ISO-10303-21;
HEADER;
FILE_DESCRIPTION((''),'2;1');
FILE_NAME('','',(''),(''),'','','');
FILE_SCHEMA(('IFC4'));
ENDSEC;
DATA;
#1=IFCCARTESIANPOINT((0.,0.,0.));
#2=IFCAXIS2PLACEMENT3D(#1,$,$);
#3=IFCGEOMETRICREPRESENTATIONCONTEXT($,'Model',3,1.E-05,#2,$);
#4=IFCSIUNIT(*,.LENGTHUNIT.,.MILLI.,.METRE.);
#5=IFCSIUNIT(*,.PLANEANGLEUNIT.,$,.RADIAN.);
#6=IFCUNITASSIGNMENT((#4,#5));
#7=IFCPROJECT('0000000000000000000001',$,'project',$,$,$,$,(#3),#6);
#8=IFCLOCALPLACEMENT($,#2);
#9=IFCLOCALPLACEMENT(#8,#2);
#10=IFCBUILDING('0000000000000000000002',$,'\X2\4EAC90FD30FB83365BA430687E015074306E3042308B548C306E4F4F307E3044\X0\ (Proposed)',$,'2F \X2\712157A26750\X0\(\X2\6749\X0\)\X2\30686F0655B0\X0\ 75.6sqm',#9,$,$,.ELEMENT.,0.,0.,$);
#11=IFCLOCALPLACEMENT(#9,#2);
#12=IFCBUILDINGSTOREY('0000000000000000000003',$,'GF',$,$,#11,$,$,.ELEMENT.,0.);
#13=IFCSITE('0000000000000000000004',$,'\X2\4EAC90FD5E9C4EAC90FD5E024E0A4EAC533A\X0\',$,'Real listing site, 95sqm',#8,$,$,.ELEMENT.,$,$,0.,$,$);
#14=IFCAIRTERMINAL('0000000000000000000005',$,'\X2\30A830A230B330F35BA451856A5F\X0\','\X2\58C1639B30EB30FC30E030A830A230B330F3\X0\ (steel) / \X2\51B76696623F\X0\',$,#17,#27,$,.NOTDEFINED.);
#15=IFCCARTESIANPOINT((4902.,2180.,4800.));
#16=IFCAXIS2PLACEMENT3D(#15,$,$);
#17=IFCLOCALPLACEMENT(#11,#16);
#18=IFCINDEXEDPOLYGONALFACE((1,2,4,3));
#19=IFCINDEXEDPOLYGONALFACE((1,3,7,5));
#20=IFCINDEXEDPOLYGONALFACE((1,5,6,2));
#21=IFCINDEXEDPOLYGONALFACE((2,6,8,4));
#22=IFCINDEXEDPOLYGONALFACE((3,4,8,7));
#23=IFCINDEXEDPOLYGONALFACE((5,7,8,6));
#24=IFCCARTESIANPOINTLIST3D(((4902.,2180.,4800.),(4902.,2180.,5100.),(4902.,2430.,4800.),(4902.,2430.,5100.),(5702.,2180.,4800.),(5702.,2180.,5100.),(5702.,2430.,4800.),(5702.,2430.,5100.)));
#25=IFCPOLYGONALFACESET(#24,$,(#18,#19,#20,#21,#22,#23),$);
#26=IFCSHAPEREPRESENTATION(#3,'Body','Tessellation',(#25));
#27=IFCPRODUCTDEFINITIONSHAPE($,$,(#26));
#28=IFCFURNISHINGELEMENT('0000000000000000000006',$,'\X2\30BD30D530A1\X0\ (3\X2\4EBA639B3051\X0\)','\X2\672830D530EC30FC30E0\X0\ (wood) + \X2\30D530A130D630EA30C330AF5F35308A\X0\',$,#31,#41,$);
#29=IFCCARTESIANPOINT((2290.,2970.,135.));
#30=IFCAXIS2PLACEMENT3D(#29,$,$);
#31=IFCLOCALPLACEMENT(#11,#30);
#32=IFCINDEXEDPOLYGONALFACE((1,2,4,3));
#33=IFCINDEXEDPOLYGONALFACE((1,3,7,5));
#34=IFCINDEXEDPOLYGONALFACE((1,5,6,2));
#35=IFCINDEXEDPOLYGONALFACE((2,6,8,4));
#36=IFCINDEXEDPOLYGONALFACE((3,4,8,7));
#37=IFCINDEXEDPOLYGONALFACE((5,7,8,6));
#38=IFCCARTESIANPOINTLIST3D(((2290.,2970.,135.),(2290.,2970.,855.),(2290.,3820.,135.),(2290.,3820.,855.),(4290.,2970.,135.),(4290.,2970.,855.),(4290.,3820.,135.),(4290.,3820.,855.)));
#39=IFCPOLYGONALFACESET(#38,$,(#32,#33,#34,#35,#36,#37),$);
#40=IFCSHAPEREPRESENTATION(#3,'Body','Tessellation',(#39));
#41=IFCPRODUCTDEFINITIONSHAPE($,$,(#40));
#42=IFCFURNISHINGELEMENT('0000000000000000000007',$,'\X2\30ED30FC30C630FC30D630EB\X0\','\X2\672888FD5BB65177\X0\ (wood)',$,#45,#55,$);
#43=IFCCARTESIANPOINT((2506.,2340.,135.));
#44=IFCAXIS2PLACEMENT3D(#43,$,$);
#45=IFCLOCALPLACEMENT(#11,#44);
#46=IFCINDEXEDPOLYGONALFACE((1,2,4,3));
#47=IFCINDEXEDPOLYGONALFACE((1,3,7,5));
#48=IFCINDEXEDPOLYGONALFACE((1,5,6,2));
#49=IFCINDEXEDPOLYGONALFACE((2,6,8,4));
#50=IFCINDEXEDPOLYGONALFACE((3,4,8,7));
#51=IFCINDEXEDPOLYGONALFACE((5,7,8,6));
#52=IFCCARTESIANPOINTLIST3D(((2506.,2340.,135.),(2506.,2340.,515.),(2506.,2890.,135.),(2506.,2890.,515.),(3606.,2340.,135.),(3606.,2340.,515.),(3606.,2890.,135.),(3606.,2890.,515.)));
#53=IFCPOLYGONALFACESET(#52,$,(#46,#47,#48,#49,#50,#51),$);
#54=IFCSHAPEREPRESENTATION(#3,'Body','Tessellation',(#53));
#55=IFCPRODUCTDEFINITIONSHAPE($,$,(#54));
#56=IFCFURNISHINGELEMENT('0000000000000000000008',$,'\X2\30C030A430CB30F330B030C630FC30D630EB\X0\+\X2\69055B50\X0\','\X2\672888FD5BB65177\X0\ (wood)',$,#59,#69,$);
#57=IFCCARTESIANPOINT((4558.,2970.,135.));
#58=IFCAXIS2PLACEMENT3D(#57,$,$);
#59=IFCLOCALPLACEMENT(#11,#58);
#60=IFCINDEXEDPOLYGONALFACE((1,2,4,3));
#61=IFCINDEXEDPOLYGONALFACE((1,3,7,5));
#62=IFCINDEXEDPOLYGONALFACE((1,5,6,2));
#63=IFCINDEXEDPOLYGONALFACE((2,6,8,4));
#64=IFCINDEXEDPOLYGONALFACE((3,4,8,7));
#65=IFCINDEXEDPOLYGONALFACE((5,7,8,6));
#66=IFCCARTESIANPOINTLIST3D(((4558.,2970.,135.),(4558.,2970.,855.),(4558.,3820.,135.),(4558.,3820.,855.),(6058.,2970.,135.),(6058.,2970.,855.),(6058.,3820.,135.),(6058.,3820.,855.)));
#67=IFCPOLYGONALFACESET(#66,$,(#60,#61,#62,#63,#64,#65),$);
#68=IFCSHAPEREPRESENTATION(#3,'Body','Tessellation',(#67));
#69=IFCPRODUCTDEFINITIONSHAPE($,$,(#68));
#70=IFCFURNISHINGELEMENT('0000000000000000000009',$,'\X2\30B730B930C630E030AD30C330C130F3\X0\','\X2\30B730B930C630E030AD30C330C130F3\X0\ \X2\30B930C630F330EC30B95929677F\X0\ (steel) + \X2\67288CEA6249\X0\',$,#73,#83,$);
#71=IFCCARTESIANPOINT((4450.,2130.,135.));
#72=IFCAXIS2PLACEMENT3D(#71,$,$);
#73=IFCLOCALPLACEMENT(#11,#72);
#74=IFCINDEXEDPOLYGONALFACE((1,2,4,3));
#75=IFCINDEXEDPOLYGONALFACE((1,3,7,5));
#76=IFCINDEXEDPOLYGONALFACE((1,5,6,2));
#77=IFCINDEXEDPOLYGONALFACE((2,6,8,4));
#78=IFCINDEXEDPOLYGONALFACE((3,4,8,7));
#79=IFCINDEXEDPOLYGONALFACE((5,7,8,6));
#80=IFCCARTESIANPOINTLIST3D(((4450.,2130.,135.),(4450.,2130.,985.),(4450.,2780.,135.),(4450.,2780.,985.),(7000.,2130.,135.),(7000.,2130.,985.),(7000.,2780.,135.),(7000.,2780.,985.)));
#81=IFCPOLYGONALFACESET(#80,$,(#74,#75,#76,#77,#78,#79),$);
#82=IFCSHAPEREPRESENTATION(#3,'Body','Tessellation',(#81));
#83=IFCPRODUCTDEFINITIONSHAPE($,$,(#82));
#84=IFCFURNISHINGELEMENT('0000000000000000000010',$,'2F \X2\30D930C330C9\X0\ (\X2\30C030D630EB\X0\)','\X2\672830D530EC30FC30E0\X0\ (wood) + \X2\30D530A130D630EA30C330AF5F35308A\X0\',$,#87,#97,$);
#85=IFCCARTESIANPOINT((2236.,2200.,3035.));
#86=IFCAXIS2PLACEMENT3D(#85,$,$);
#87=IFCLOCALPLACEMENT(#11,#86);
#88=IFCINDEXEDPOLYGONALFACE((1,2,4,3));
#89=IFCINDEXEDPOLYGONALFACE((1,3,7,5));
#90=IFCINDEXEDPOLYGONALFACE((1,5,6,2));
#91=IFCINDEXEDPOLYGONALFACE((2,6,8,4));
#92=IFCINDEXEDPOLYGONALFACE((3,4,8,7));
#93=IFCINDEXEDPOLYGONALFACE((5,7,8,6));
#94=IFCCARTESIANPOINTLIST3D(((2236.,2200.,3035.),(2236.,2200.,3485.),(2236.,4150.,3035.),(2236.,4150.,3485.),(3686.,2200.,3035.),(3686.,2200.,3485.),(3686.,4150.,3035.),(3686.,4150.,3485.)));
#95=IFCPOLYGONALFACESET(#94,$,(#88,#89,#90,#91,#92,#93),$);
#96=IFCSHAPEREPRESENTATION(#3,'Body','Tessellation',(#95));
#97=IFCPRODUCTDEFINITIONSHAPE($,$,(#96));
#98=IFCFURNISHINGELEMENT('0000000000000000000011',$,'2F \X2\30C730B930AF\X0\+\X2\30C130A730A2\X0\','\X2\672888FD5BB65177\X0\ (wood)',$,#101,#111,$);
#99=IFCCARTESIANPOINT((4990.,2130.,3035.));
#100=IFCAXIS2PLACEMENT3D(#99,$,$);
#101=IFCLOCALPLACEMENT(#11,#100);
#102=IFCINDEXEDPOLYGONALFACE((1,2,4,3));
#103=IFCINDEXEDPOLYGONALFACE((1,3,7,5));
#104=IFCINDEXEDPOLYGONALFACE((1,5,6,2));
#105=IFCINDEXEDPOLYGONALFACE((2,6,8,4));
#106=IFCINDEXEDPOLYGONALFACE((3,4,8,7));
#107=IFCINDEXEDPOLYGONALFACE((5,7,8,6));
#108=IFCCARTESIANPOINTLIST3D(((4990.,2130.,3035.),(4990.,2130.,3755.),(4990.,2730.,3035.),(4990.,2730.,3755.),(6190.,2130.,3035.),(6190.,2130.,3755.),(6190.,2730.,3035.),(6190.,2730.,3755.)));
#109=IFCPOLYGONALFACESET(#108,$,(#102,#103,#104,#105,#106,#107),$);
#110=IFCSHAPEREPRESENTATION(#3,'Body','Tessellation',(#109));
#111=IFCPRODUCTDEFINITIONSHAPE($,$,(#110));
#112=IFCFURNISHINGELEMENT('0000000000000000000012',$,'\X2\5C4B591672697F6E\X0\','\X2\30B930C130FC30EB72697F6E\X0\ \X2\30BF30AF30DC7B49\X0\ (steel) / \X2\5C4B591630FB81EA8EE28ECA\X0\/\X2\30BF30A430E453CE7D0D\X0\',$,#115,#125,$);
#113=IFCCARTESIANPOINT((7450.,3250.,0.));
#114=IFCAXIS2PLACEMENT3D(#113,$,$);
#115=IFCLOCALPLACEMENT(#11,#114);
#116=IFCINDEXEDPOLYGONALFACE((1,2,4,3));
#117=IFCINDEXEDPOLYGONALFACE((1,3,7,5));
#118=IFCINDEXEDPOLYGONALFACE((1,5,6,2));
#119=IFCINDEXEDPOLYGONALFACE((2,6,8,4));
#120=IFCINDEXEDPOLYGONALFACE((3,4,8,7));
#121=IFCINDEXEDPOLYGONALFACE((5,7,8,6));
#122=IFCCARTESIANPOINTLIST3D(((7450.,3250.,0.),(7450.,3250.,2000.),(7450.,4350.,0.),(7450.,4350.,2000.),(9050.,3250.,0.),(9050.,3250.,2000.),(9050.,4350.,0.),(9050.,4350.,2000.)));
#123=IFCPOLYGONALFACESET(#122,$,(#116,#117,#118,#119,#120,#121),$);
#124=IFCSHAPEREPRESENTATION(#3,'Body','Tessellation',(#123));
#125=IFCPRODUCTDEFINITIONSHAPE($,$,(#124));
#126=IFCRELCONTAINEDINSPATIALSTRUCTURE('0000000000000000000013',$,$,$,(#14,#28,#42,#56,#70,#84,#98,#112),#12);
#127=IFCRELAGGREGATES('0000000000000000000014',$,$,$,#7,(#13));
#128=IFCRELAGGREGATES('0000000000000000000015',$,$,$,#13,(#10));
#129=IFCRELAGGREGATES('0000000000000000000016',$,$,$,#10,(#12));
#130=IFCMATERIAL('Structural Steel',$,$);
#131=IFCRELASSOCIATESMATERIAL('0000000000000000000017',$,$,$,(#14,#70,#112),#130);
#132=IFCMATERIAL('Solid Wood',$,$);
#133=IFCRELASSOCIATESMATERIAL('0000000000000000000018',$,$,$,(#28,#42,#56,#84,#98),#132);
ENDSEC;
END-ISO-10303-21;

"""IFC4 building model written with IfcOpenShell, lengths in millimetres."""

from ifc_helpers import new_model, si_unit, frame, frame_2d, origin, place, context, project, spatial, rectangle, extrude, material, element, save


model = new_model("IFC4")

# Units and contexts
model_context = context("Model", 3, precision=1e-05, world=origin())
ifc_project = project(units=[si_unit("LENGTHUNIT", "METRE", prefix="MILLI"), si_unit("PLANEANGLEUNIT", "RADIAN")], contexts=[model_context])

# Site, building, storey
site_placement = place(None, origin())
site = spatial("IfcSite", under=ifc_project, at=site_placement, Name="京都府京都市上京区", ObjectType="Real listing site, 95sqm", CompositionType="ELEMENT", RefElevation=0.0)
building_placement = place(site_placement, origin())
building = spatial("IfcBuilding", under=site, at=building_placement, Name="京都・茶室と縁側のある和の住まい (Proposed)", ObjectType="2F 無垢材(杉)と漆喰 75.6sqm", CompositionType="ELEMENT", ElevationOfRefHeight=0.0, ElevationOfTerrain=0.0)
storey_placement = place(building_placement, origin())
storey = spatial("IfcBuildingStorey", under=building, at=storey_placement, Name="GF", CompositionType="ELEMENT", Elevation=0.0)

# Shared definitions
ifc_material_1 = material(Name="Solid Wood")

# Shared definitions
ifc_material_2 = material(Name="Structural Steel")

# Air terminal
air_terminal_1_placement = place(storey_placement, frame((4902.0, 2180.0, 4800.0)))
element("IfcAirTerminal", 1, at=air_terminal_1_placement, inside=storey, material=ifc_material_2, Name="エアコン室内機", Description="壁掛ルームエアコン (steel) / 冷暖房", PredefinedType="NOTDEFINED", context=model_context, shape_type="SweptSolid", body=[
    extrude(rectangle(XDim=800.0, YDim=250.0, at=frame_2d((400.0, 125.0))), frame((4902.0, 2180.0, 4800.0)), (0.0, 0.0, 1.0), 300.0),
])

# Furnishing elements
furnishing_1_placement = place(storey_placement, frame((2290.0, 2970.0, 135.0)))
element("IfcFurnishingElement", 2, at=furnishing_1_placement, inside=storey, material=ifc_material_1, Name="ソファ (3人掛け)", Description="木フレーム (wood) + ファブリック張り", context=model_context, shape_type="SweptSolid", body=[
    extrude(rectangle(XDim=2000.0, YDim=850.0, at=frame_2d((1000.0, 425.0))), frame((2290.0, 2970.0, 135.0)), (0.0, 0.0, 1.0), 720.0),
])
furnishing_2_placement = place(storey_placement, frame((2506.0, 2340.0, 135.0)))
element("IfcFurnishingElement", 3, at=furnishing_2_placement, inside=storey, material=ifc_material_1, Name="ローテーブル", Description="木製家具 (wood)", context=model_context, shape_type="SweptSolid", body=[
    extrude(rectangle(XDim=1100.0, YDim=550.0, at=frame_2d((550.0, 275.0))), frame((2506.0, 2340.0, 135.0)), (0.0, 0.0, 1.0), 380.0),
])
furnishing_3_placement = place(storey_placement, frame((4558.0, 2970.0, 135.0)))
element("IfcFurnishingElement", 4, at=furnishing_3_placement, inside=storey, material=ifc_material_1, Name="ダイニングテーブル+椅子", Description="木製家具 (wood)", context=model_context, shape_type="SweptSolid", body=[
    extrude(rectangle(XDim=1500.0, YDim=850.0, at=frame_2d((750.0, 425.0))), frame((4558.0, 2970.0, 135.0)), (0.0, 0.0, 1.0), 720.0),
])
furnishing_4_placement = place(storey_placement, frame((4450.0, 2130.0, 135.0)))
element("IfcFurnishingElement", 5, at=furnishing_4_placement, inside=storey, material=ifc_material_2, Name="システムキッチン", Description="システムキッチン ステンレス天板 (steel) + 木質扉", context=model_context, shape_type="SweptSolid", body=[
    extrude(rectangle(XDim=2550.0, YDim=650.0, at=frame_2d((1275.0, 325.0))), frame((4450.0, 2130.0, 135.0)), (0.0, 0.0, 1.0), 850.0),
])
furnishing_5_placement = place(storey_placement, frame((2236.0, 2200.0, 3035.0)))
element("IfcFurnishingElement", 6, at=furnishing_5_placement, inside=storey, material=ifc_material_1, Name="2F ベッド (ダブル)", Description="木フレーム (wood) + ファブリック張り", context=model_context, shape_type="SweptSolid", body=[
    extrude(rectangle(XDim=1450.0, YDim=1950.0, at=frame_2d((725.0, 975.0))), frame((2236.0, 2200.0, 3035.0)), (0.0, 0.0, 1.0), 450.0),
])
furnishing_6_placement = place(storey_placement, frame((4990.0, 2130.0, 3035.0)))
element("IfcFurnishingElement", 7, at=furnishing_6_placement, inside=storey, material=ifc_material_1, Name="2F デスク+チェア", Description="木製家具 (wood)", context=model_context, shape_type="SweptSolid", body=[
    extrude(rectangle(XDim=1200.0, YDim=600.0, at=frame_2d((600.0, 300.0))), frame((4990.0, 2130.0, 3035.0)), (0.0, 0.0, 1.0), 720.0),
])
furnishing_7_placement = place(storey_placement, frame((7450.0, 3250.0, 0.0)))
element("IfcFurnishingElement", 8, at=furnishing_7_placement, inside=storey, material=ifc_material_2, Name="屋外物置", Description="スチール物置 タクボ等 (steel) / 屋外・自転車/タイヤ収納", context=model_context, shape_type="SweptSolid", body=[
    extrude(rectangle(XDim=1600.0, YDim=1100.0, at=frame_2d((800.0, 550.0))), frame((7450.0, 3250.0, 0.0)), (0.0, 0.0, 1.0), 2000.0),
])

save(model, "model.ifc")
